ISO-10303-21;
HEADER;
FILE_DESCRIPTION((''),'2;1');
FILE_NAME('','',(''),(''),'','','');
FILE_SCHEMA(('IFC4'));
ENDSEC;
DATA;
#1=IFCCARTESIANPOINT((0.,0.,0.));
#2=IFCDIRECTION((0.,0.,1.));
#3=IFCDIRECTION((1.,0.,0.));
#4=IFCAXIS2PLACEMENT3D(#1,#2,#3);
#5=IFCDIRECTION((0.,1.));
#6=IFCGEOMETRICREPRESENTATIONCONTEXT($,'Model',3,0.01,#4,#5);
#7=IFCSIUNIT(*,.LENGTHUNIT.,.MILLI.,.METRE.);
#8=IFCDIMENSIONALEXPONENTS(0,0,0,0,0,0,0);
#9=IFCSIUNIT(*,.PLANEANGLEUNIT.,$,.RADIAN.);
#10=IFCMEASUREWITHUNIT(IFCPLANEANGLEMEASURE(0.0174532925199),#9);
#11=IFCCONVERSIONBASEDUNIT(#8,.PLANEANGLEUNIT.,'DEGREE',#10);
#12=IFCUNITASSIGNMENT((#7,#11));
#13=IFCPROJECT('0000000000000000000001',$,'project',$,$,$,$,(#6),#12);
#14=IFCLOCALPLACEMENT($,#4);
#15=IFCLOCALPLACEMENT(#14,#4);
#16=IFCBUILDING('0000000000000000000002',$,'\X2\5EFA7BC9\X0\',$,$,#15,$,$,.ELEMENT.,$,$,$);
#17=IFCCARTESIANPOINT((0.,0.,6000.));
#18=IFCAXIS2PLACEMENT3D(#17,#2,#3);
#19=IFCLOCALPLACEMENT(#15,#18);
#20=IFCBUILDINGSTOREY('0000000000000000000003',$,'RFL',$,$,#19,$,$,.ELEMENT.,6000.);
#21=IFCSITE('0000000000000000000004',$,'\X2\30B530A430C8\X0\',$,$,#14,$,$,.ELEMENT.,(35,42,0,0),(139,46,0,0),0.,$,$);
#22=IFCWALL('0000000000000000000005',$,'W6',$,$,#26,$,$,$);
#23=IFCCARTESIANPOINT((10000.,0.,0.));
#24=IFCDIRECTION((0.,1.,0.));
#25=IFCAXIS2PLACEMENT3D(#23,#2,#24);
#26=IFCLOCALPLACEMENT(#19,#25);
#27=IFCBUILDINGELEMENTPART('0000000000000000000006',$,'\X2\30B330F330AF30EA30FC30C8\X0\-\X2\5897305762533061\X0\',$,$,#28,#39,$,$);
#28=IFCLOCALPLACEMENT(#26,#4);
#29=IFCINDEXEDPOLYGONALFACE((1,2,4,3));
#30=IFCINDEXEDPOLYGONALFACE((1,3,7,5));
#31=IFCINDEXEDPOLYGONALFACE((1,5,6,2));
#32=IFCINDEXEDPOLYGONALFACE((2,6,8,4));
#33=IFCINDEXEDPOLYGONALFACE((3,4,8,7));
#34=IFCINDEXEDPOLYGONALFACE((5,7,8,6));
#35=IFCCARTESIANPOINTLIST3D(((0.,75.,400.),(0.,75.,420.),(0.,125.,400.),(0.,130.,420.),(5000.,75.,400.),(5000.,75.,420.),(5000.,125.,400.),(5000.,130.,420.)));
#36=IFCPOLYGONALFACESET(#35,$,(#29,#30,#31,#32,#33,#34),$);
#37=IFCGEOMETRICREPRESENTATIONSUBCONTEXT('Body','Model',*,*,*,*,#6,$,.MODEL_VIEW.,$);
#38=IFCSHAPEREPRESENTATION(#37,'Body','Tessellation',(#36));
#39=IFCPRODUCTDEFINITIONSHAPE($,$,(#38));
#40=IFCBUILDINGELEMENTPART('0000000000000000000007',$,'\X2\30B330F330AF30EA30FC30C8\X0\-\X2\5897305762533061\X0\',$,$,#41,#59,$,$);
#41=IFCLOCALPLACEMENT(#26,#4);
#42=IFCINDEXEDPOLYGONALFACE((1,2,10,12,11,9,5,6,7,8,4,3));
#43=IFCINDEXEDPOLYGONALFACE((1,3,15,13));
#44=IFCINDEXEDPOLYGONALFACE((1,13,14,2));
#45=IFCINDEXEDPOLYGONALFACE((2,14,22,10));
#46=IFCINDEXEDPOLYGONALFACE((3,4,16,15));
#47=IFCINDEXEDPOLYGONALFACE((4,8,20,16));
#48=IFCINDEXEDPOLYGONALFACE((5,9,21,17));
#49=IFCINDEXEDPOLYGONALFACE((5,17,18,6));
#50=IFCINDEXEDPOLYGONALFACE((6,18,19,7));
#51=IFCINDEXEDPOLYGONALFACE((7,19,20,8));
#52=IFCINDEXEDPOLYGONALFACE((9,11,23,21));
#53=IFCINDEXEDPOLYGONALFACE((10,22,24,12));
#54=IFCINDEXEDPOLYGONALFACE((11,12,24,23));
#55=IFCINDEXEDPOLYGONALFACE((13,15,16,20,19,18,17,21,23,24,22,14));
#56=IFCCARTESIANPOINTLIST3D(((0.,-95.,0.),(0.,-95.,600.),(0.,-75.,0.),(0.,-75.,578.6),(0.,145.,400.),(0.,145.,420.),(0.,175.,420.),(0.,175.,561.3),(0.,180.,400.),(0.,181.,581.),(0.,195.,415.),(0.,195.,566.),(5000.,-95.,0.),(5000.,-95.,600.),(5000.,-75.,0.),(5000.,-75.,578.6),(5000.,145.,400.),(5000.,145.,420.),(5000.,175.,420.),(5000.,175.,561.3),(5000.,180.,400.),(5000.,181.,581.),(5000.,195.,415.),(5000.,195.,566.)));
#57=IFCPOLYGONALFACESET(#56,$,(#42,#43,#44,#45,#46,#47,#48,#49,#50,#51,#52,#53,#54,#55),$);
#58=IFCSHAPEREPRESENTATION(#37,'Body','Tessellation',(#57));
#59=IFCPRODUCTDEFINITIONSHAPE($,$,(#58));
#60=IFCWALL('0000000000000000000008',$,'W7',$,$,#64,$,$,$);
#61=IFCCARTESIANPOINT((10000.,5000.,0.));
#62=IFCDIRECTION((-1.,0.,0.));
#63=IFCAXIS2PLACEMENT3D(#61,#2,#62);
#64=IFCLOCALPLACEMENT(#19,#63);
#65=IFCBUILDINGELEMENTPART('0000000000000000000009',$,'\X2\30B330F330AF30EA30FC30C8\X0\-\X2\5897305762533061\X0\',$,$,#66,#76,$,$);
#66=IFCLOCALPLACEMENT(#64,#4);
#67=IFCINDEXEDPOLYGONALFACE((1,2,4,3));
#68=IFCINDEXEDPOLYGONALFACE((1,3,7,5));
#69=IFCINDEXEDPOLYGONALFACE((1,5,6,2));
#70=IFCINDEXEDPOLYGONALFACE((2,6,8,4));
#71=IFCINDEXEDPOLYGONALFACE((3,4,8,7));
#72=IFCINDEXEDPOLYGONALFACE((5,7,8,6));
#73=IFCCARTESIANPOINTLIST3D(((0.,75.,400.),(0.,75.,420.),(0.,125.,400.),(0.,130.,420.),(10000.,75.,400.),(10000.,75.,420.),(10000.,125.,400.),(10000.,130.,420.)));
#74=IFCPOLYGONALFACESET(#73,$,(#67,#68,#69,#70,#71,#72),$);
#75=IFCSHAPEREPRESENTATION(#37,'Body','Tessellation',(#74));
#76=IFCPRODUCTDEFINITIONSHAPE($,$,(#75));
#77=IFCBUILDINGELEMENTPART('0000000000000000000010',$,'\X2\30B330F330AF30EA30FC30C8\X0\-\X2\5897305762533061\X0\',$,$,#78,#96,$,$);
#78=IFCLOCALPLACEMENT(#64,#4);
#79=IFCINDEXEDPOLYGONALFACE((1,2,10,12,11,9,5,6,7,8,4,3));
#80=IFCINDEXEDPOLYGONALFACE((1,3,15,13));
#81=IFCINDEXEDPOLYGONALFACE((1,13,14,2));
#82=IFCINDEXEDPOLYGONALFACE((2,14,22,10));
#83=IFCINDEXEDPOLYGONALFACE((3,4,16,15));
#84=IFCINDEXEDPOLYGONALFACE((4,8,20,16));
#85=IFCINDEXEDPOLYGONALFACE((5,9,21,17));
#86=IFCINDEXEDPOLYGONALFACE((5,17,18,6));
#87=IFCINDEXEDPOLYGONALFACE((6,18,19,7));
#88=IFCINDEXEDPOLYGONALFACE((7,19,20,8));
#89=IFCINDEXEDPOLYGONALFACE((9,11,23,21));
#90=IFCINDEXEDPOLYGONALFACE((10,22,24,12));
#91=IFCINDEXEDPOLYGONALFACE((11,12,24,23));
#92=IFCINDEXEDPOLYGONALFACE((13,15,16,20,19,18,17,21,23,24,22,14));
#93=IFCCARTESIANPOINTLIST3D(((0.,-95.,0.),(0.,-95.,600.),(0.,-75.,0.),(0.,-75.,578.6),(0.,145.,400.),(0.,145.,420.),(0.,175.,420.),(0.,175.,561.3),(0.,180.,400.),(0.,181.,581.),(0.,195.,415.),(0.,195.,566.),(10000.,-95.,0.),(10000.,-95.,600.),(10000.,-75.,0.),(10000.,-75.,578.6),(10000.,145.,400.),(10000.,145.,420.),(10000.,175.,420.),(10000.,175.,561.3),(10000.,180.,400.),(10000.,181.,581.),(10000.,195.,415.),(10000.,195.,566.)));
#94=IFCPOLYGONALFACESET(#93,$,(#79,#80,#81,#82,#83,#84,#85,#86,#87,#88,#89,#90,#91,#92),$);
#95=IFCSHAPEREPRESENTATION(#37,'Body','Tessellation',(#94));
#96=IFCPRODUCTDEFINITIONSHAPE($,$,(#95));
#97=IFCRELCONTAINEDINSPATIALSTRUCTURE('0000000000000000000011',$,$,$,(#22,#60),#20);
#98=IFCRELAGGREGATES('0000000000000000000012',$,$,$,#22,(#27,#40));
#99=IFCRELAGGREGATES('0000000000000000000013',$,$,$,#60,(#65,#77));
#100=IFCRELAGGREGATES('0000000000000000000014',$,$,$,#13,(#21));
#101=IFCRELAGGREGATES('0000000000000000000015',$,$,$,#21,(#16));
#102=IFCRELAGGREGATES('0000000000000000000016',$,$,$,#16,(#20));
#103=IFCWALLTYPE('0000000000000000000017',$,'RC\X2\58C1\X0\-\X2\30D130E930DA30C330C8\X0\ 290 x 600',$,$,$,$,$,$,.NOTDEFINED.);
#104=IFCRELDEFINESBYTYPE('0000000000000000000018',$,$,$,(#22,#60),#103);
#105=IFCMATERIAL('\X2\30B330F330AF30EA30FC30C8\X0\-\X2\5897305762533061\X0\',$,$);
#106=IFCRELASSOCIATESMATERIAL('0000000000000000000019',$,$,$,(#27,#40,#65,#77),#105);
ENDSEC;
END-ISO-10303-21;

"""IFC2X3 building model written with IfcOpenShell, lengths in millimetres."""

from ifc_helpers import new_model, entity, si_unit, converted_unit, direction, frame, origin_with_axes, place, context, subcontext, project, spatial, polyline, outline, extrude, material, type_object, element, aggregate, save


model = new_model("IFC2X3")

# Units and contexts
model_context = context("Model", 3, precision=0.01, world=origin_with_axes(), true_north=direction((0.0, 1.0)))
body_context = subcontext(model_context, "Body", "Model", "MODEL_VIEW")
ifc_project = project(units=[si_unit("LENGTHUNIT", "METRE", prefix="MILLI"), converted_unit("PLANEANGLEUNIT", "DEGREE", entity("IfcPlaneAngleMeasure", 0.0174532925199), si_unit("PLANEANGLEUNIT", "RADIAN"), dimensions=[0, 0, 0, 0, 0, 0, 0])], contexts=[model_context])

# Site, building, storey
site_placement = place(None, origin_with_axes())
site = spatial("IfcSite", under=ifc_project, at=site_placement, Name="サイト", CompositionType="ELEMENT", RefLatitude=(35, 42, 0, 0), RefLongitude=(139, 46, 0, 0), RefElevation=0.0)
building_placement = place(site_placement, origin_with_axes())
building = spatial("IfcBuilding", under=site, at=building_placement, Name="建築", CompositionType="ELEMENT")
storey_placement = place(building_placement, frame((0.0, 0.0, 6000.0), z_axis=(0.0, 0.0, 1.0), x_axis=(1.0, 0.0, 0.0)))
storey = spatial("IfcBuildingStorey", under=building, at=storey_placement, Name="RFL", CompositionType="ELEMENT", Elevation=6000.0)

# Walls, building element parts
wall_type = type_object("IfcWallType", Name="RC壁-パラペット 290 x 600", PredefinedType="NOTDEFINED")
ifc_material_1 = material(Name="コンクリート-増し打ち")
wall_1_placement = place(storey_placement, frame((10000.0, 0.0, 0.0), z_axis=(0.0, 0.0, 1.0), x_axis=(0.0, 1.0, 0.0)))
wall_1 = element("IfcWall", 1, at=wall_1_placement, inside=storey, type_object=wall_type, Name="W6")
building_element_part_1_placement = place(wall_1_placement, origin_with_axes())
building_element_part_1 = element("IfcBuildingElementPart", 2, at=building_element_part_1_placement, material=ifc_material_1, Name="コンクリート-増し打ち", context=body_context, shape_type="SweptSolid", body=[
    extrude(outline(polyline([(-130.0, 420.0), (-125.0, 400.0), (-75.0, 400.0), (-75.0, 420.0), (-130.0, 420.0)])), frame((0.0, 0.0, 0.0), z_axis=(-1.0, 0.0, 0.0), x_axis=(0.0, -1.0, 0.0)), (0.0, 0.0, -1.0), 5000.0),
])
building_element_part_2_placement = place(wall_1_placement, origin_with_axes())
building_element_part_2 = element("IfcBuildingElementPart", 3, at=building_element_part_2_placement, material=ifc_material_1, Name="コンクリート-増し打ち", context=body_context, shape_type="SweptSolid", body=[
    extrude(outline(polyline([(-195.0, 415.0), (-180.0, 400.0), (-145.0, 400.0), (-145.0, 420.0), (-175.0, 420.0), (-175.0, 561.3), (75.0, 578.6), (75.0, 0.0), (95.0, 0.0), (95.0, 600.0), (-181.0, 581.0), (-195.0, 566.0), (-195.0, 415.0)])), frame((0.0, 0.0, 0.0), z_axis=(-1.0, 0.0, 0.0), x_axis=(0.0, -1.0, 0.0)), (0.0, 0.0, -1.0), 5000.0),
])
aggregate(wall_1, [building_element_part_1, building_element_part_2])
wall_2_placement = place(storey_placement, frame((10000.0, 5000.0, 0.0), z_axis=(0.0, 0.0, 1.0), x_axis=(-1.0, 0.0, 0.0)))
wall_2 = element("IfcWall", 4, at=wall_2_placement, inside=storey, type_object=wall_type, Name="W7")
building_element_part_3_placement = place(wall_2_placement, origin_with_axes())
building_element_part_3 = element("IfcBuildingElementPart", 5, at=building_element_part_3_placement, material=ifc_material_1, Name="コンクリート-増し打ち", context=body_context, shape_type="SweptSolid", body=[
    extrude(outline(polyline([(-130.0, 420.0), (-125.0, 400.0), (-75.0, 400.0), (-75.0, 420.0), (-130.0, 420.0)])), frame((0.0, 0.0, 0.0), z_axis=(-1.0, 0.0, 0.0), x_axis=(0.0, -1.0, 0.0)), (0.0, 0.0, -1.0), 10000.0),
])
building_element_part_4_placement = place(wall_2_placement, origin_with_axes())
building_element_part_4 = element("IfcBuildingElementPart", 6, at=building_element_part_4_placement, material=ifc_material_1, Name="コンクリート-増し打ち", context=body_context, shape_type="SweptSolid", body=[
    extrude(outline(polyline([(-195.0, 415.0), (-180.0, 400.0), (-145.0, 400.0), (-145.0, 420.0), (-175.0, 420.0), (-175.0, 561.3), (75.0, 578.6), (75.0, 0.0), (95.0, 0.0), (95.0, 600.0), (-181.0, 581.0), (-195.0, 566.0), (-195.0, 415.0)])), frame((0.0, 0.0, 0.0), z_axis=(-1.0, 0.0, 0.0), x_axis=(0.0, -1.0, 0.0)), (0.0, 0.0, -1.0), 10000.0),
])
aggregate(wall_2, [building_element_part_3, building_element_part_4])

save(model, "model.ifc")
